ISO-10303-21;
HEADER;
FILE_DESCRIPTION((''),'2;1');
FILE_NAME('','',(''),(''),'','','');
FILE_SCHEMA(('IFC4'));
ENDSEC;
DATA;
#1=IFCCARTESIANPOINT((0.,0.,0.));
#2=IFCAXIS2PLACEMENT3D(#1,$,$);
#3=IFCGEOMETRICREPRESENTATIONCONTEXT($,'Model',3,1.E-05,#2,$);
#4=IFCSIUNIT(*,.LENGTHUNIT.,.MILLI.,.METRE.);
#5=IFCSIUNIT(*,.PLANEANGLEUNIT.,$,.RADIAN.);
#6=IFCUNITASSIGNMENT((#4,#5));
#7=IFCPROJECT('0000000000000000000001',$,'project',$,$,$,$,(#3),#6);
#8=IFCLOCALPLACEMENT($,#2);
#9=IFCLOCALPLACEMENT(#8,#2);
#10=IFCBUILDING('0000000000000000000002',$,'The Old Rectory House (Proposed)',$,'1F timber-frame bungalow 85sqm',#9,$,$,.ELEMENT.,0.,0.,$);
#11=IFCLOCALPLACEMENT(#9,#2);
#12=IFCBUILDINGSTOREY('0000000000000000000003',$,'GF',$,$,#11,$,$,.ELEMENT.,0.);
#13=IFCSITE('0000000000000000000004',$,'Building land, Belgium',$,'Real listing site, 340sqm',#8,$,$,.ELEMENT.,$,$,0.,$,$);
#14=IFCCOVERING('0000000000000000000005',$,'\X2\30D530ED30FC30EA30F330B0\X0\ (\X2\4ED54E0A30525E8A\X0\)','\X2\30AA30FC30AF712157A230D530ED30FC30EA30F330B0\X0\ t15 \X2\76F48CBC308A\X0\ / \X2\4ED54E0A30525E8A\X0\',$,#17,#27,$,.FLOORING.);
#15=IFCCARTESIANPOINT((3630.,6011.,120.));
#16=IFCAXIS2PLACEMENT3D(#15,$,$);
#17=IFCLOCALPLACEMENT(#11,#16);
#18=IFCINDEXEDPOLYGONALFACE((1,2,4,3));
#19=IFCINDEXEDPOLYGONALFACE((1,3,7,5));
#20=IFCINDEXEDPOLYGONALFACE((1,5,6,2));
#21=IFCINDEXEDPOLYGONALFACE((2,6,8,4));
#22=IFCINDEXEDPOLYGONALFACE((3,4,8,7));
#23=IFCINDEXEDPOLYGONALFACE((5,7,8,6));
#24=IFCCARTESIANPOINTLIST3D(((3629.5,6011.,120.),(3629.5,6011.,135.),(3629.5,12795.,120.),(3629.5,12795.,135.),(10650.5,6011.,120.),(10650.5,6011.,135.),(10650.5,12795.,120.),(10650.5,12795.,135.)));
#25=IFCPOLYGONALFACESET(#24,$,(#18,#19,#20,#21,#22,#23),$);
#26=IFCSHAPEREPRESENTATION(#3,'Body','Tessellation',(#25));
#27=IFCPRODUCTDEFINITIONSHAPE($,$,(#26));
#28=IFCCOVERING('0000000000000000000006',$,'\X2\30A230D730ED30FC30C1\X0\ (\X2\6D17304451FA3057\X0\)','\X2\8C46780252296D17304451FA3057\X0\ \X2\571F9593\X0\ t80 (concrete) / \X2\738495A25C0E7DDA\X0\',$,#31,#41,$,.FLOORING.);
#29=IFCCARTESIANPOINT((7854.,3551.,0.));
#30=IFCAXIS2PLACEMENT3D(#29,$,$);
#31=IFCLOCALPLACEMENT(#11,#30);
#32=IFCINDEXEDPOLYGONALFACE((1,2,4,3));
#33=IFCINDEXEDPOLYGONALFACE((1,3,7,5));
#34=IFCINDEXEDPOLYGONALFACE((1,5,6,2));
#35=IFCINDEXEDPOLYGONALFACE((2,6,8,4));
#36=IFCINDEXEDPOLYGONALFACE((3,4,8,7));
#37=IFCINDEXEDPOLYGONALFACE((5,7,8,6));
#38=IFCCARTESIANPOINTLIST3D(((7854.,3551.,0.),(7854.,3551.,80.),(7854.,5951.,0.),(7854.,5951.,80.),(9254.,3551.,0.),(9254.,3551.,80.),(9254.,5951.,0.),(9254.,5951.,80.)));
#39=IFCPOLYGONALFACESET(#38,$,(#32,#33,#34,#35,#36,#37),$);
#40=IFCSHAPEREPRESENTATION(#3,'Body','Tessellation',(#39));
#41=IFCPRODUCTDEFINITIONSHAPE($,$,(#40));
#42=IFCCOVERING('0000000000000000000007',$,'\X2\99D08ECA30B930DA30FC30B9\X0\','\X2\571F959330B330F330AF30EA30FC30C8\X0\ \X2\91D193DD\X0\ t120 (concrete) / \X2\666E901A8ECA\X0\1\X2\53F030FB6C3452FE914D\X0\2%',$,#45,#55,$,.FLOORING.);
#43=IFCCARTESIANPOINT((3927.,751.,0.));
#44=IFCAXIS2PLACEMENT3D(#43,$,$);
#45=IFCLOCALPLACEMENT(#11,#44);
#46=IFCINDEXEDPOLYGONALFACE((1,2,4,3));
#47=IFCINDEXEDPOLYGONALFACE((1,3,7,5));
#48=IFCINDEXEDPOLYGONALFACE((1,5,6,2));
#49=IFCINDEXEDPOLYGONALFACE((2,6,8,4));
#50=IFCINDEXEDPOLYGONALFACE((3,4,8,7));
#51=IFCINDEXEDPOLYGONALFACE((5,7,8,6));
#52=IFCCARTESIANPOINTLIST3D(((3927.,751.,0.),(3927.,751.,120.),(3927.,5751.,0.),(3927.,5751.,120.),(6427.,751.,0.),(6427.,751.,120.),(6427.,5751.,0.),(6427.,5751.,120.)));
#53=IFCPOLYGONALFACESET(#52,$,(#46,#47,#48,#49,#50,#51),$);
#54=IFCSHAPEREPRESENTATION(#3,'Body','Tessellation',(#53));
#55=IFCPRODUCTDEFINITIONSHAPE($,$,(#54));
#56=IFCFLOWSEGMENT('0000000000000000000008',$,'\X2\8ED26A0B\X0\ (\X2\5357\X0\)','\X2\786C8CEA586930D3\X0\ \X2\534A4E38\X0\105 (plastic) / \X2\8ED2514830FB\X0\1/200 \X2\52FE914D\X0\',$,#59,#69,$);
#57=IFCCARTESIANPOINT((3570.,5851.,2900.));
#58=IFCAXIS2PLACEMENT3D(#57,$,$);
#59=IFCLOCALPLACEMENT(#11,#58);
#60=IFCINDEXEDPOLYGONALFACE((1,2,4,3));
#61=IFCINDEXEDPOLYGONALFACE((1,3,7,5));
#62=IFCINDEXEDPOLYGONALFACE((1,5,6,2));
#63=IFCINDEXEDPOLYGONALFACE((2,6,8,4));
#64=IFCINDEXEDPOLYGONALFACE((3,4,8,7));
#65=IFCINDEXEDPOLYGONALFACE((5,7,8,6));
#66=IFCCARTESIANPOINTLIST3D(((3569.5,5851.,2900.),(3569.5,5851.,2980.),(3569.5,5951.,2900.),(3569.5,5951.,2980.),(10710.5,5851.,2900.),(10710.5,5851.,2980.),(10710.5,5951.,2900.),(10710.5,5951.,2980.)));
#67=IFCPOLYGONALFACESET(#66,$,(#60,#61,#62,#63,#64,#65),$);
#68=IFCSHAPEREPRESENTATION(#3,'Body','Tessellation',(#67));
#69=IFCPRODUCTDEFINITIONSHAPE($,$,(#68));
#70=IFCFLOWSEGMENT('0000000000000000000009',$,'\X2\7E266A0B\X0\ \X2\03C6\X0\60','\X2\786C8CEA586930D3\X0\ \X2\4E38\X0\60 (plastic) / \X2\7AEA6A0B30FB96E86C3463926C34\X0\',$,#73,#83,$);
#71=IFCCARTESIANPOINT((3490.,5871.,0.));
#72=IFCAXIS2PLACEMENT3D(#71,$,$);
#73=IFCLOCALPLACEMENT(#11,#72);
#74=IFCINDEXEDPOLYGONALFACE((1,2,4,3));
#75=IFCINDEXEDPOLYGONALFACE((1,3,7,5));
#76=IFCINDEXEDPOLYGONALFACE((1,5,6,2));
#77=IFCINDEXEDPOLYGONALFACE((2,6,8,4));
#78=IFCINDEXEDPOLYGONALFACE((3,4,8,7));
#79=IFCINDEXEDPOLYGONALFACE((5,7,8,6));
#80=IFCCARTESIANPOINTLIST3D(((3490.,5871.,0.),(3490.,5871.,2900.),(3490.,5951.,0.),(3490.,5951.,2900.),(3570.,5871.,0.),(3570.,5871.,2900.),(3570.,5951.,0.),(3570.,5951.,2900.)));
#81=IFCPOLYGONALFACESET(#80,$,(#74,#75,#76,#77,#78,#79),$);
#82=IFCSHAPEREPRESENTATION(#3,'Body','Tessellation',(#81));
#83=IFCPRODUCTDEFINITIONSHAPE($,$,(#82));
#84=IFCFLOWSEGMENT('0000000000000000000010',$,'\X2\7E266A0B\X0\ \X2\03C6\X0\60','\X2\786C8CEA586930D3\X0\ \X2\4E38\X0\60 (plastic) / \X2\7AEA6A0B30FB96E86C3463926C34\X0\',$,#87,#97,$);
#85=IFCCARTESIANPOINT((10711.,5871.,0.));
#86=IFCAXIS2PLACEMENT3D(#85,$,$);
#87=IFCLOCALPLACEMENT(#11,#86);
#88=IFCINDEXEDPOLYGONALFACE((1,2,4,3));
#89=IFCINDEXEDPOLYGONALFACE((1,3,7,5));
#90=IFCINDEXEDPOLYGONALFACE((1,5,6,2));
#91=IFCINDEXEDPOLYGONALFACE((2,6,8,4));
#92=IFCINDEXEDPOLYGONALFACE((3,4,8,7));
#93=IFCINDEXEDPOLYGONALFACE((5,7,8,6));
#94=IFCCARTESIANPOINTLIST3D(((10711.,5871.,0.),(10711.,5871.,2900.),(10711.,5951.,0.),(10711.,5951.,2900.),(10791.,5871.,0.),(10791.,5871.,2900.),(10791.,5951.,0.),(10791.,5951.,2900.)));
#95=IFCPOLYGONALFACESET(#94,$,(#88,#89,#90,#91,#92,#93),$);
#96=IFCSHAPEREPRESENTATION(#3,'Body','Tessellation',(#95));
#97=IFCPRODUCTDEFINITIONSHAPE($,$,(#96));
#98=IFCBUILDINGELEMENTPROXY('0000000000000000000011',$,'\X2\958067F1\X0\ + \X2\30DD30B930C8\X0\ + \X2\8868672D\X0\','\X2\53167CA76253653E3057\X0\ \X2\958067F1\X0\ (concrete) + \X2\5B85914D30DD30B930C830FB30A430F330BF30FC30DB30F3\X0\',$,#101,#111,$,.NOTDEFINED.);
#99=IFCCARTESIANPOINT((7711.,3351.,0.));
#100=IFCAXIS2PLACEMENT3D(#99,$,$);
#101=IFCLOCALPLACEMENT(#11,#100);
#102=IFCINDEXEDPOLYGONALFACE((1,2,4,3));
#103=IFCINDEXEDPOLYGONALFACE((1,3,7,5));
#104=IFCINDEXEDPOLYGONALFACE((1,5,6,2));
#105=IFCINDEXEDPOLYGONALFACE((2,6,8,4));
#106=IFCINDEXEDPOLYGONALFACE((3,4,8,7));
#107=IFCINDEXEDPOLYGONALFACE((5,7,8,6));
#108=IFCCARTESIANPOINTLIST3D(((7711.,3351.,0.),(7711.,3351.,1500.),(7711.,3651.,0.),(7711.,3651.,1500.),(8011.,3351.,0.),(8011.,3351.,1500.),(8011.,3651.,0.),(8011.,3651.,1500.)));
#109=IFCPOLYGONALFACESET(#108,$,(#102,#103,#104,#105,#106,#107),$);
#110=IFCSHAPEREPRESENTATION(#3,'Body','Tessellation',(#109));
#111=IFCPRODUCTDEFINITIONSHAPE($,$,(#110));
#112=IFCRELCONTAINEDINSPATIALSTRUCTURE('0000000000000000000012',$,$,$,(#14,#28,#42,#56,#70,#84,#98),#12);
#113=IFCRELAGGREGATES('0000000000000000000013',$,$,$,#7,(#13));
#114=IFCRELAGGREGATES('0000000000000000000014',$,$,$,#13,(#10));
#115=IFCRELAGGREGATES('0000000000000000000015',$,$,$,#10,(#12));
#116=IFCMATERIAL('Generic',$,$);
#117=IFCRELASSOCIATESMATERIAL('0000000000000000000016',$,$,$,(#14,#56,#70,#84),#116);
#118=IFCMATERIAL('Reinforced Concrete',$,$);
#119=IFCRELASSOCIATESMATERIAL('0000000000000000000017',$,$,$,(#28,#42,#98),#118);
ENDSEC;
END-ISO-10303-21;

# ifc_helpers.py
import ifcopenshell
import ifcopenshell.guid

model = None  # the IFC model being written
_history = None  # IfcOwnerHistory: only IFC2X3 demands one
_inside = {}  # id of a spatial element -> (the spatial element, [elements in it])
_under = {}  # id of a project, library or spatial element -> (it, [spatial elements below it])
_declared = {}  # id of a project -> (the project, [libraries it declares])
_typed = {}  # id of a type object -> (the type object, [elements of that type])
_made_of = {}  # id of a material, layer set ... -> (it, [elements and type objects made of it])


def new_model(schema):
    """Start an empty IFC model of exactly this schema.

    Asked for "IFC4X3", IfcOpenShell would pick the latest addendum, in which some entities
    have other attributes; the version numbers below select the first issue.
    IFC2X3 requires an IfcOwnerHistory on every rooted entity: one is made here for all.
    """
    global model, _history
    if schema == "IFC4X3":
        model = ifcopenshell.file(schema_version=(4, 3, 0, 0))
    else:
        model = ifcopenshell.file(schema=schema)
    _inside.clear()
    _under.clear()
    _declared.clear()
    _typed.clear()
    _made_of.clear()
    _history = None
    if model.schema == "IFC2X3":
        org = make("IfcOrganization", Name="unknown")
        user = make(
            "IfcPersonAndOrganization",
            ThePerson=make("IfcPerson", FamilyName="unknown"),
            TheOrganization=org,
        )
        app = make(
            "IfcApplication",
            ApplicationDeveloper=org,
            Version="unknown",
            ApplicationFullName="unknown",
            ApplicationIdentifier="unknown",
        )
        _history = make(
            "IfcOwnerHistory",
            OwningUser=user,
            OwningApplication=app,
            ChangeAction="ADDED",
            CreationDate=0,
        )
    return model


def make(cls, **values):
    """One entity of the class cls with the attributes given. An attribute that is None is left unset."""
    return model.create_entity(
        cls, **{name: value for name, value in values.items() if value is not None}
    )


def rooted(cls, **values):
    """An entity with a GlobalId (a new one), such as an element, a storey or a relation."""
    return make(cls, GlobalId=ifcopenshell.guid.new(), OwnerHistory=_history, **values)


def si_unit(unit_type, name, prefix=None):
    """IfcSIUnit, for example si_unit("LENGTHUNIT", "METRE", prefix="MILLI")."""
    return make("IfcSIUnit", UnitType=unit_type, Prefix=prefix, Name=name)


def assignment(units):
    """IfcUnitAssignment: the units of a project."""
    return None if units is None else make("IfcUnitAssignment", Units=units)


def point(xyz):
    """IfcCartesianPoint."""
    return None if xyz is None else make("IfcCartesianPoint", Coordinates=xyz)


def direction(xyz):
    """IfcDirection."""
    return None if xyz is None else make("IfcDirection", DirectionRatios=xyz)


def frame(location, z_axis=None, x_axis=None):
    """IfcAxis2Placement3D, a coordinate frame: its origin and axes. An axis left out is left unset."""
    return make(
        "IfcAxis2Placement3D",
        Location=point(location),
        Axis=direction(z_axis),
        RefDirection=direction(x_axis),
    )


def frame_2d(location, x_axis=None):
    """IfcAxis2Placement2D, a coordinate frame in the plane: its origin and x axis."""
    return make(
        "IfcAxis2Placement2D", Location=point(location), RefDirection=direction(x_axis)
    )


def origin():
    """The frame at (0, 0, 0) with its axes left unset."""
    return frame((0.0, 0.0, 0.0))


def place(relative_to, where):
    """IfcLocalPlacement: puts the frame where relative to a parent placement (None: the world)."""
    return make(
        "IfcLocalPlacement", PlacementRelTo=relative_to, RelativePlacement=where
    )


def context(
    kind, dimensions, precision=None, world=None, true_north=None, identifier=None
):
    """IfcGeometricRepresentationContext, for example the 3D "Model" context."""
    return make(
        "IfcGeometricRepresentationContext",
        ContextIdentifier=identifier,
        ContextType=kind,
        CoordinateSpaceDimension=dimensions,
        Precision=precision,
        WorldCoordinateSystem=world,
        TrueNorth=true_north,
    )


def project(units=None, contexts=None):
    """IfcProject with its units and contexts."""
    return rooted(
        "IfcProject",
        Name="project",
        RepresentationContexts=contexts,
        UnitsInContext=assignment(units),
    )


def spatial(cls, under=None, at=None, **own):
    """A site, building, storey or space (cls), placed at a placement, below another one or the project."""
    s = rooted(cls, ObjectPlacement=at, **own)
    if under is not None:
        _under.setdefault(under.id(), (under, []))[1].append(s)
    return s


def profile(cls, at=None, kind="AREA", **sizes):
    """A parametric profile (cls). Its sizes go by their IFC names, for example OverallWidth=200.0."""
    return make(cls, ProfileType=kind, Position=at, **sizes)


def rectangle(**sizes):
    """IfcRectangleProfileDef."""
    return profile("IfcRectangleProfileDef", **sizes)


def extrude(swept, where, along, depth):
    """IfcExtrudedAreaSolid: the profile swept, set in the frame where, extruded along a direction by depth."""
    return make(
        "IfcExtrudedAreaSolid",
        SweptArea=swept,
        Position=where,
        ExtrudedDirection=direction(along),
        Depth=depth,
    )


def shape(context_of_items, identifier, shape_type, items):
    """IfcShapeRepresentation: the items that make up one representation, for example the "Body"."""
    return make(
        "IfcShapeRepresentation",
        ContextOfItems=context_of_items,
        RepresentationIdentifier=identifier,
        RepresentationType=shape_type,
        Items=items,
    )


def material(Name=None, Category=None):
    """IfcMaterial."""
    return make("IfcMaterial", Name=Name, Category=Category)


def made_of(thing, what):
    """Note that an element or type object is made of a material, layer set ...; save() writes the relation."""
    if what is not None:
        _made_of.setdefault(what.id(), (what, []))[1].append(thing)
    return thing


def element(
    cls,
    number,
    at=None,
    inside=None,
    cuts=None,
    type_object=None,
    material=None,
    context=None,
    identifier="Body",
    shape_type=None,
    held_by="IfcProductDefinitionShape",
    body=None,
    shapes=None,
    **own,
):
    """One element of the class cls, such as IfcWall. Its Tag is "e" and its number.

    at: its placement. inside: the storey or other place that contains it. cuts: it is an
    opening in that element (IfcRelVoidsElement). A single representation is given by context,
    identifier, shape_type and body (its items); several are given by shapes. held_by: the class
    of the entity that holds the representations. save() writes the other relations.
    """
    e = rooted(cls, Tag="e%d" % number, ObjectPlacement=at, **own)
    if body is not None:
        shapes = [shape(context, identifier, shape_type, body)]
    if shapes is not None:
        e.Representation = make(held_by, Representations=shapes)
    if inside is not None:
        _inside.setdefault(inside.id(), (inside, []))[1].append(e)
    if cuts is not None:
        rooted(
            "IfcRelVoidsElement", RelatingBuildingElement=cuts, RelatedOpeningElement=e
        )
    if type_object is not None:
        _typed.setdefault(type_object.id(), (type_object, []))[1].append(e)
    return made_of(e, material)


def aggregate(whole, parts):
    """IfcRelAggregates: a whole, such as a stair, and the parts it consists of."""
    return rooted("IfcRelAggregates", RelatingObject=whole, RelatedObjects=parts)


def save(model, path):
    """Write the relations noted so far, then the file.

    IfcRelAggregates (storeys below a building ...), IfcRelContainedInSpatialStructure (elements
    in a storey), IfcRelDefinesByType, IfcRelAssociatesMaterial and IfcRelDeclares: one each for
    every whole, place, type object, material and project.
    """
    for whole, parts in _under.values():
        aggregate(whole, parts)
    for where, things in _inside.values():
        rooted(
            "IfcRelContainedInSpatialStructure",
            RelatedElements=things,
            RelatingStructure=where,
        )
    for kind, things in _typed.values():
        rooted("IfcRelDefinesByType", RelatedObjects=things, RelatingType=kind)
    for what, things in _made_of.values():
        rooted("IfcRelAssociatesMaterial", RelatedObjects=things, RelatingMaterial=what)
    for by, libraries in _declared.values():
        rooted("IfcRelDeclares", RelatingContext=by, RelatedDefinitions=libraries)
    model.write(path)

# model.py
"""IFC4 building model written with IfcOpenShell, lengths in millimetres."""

from ifc_helpers import new_model, si_unit, frame, frame_2d, origin, place, context, project, spatial, rectangle, extrude, material, element, save


model = new_model("IFC4")

# Units and contexts
model_context = context("Model", 3, precision=1e-05, world=origin())
ifc_project = project(units=[si_unit("LENGTHUNIT", "METRE", prefix="MILLI"), si_unit("PLANEANGLEUNIT", "RADIAN")], contexts=[model_context])

# Site, building, storey
site_placement = place(None, origin())
site = spatial("IfcSite", under=ifc_project, at=site_placement, Name="Building land, Belgium", ObjectType="Real listing site, 340sqm", CompositionType="ELEMENT", RefElevation=0.0)
building_placement = place(site_placement, origin())
building = spatial("IfcBuilding", under=site, at=building_placement, Name="The Old Rectory House (Proposed)", ObjectType="1F timber-frame bungalow 85sqm", CompositionType="ELEMENT", ElevationOfRefHeight=0.0, ElevationOfTerrain=0.0)
storey_placement = place(building_placement, origin())
storey = spatial("IfcBuildingStorey", under=building, at=storey_placement, Name="GF", CompositionType="ELEMENT", Elevation=0.0)

# Shared definitions
ifc_material_1 = material(Name="Reinforced Concrete")

# Coverings
ifc_material_2 = material(Name="Generic")
covering_1_placement = place(storey_placement, frame((3630.0, 6011.0, 120.0)))
element("IfcCovering", 1, at=covering_1_placement, inside=storey, material=ifc_material_2, Name="フローリング (仕上げ床)", Description="オーク無垢フローリング t15 直貼り / 仕上げ床", PredefinedType="FLOORING", context=model_context, shape_type="SweptSolid", body=[
    extrude(rectangle(XDim=7021.0, YDim=6784.0, at=frame_2d((3510.0, 3392.0))), frame((3630.0, 6011.0, 120.0)), (0.0, 0.0, 1.0), 15.0),
])
covering_2_placement = place(storey_placement, frame((7854.0, 3551.0, 0.0)))
element("IfcCovering", 2, at=covering_2_placement, inside=storey, material=ifc_material_1, Name="アプローチ (洗い出し)", Description="豆砂利洗い出し 土間 t80 (concrete) / 玄関導線", PredefinedType="FLOORING", context=model_context, shape_type="SweptSolid", body=[
    extrude(rectangle(XDim=1400.0, YDim=2400.0, at=frame_2d((700.0, 1200.0))), frame((7854.0, 3551.0, 0.0)), (0.0, 0.0, 1.0), 80.0),
])
covering_3_placement = place(storey_placement, frame((3927.0, 751.0, 0.0)))
element("IfcCovering", 3, at=covering_3_placement, inside=storey, material=ifc_material_1, Name="駐車スペース", Description="土間コンクリート 金鏝 t120 (concrete) / 普通車1台・水勾配2%", PredefinedType="FLOORING", context=model_context, shape_type="SweptSolid", body=[
    extrude(rectangle(XDim=2500.0, YDim=5000.0, at=frame_2d((1250.0, 2500.0))), frame((3927.0, 751.0, 0.0)), (0.0, 0.0, 1.0), 120.0),
])

# Flow segments
flow_segment_1_placement = place(storey_placement, frame((3570.0, 5851.0, 2900.0)))
element("IfcFlowSegment", 4, at=flow_segment_1_placement, inside=storey, material=ifc_material_2, Name="軒樋 (南)", Description="硬質塩ビ 半丸105 (plastic) / 軒先・1/200 勾配", context=model_context, shape_type="SweptSolid", body=[
    extrude(rectangle(XDim=7141.0, YDim=100.0, at=frame_2d((3570.0, 50.0))), frame((3570.0, 5851.0, 2900.0)), (0.0, 0.0, 1.0), 80.0),
])
flow_segment_2_placement = place(storey_placement, frame((3490.0, 5871.0, 0.0)))
element("IfcFlowSegment", 5, at=flow_segment_2_placement, inside=storey, material=ifc_material_2, Name="縦樋 φ60", Description="硬質塩ビ 丸60 (plastic) / 竪樋・雨水排水", context=model_context, shape_type="SweptSolid", body=[
    extrude(rectangle(XDim=80.0, YDim=80.0, at=frame_2d((40.0, 40.0))), frame((3490.0, 5871.0, 0.0)), (0.0, 0.0, 1.0), 2900.0),
])
flow_segment_3_placement = place(storey_placement, frame((10711.0, 5871.0, 0.0)))
element("IfcFlowSegment", 6, at=flow_segment_3_placement, inside=storey, material=ifc_material_2, Name="縦樋 φ60", Description="硬質塩ビ 丸60 (plastic) / 竪樋・雨水排水", context=model_context, shape_type="SweptSolid", body=[
    extrude(rectangle(XDim=80.0, YDim=80.0, at=frame_2d((40.0, 40.0))), frame((10711.0, 5871.0, 0.0)), (0.0, 0.0, 1.0), 2900.0),
])

# Building element proxy
proxy_placement = place(storey_placement, frame((7711.0, 3351.0, 0.0)))
element("IfcBuildingElementProxy", 7, at=proxy_placement, inside=storey, material=ifc_material_1, Name="門柱 + ポスト + 表札", Description="化粧打放し 門柱 (concrete) + 宅配ポスト・インターホン", PredefinedType="NOTDEFINED", context=model_context, shape_type="SweptSolid", body=[
    extrude(rectangle(XDim=300.0, YDim=300.0, at=frame_2d((150.0, 150.0))), frame((7711.0, 3351.0, 0.0)), (0.0, 0.0, 1.0), 1500.0),
])

save(model, "model.ifc")
